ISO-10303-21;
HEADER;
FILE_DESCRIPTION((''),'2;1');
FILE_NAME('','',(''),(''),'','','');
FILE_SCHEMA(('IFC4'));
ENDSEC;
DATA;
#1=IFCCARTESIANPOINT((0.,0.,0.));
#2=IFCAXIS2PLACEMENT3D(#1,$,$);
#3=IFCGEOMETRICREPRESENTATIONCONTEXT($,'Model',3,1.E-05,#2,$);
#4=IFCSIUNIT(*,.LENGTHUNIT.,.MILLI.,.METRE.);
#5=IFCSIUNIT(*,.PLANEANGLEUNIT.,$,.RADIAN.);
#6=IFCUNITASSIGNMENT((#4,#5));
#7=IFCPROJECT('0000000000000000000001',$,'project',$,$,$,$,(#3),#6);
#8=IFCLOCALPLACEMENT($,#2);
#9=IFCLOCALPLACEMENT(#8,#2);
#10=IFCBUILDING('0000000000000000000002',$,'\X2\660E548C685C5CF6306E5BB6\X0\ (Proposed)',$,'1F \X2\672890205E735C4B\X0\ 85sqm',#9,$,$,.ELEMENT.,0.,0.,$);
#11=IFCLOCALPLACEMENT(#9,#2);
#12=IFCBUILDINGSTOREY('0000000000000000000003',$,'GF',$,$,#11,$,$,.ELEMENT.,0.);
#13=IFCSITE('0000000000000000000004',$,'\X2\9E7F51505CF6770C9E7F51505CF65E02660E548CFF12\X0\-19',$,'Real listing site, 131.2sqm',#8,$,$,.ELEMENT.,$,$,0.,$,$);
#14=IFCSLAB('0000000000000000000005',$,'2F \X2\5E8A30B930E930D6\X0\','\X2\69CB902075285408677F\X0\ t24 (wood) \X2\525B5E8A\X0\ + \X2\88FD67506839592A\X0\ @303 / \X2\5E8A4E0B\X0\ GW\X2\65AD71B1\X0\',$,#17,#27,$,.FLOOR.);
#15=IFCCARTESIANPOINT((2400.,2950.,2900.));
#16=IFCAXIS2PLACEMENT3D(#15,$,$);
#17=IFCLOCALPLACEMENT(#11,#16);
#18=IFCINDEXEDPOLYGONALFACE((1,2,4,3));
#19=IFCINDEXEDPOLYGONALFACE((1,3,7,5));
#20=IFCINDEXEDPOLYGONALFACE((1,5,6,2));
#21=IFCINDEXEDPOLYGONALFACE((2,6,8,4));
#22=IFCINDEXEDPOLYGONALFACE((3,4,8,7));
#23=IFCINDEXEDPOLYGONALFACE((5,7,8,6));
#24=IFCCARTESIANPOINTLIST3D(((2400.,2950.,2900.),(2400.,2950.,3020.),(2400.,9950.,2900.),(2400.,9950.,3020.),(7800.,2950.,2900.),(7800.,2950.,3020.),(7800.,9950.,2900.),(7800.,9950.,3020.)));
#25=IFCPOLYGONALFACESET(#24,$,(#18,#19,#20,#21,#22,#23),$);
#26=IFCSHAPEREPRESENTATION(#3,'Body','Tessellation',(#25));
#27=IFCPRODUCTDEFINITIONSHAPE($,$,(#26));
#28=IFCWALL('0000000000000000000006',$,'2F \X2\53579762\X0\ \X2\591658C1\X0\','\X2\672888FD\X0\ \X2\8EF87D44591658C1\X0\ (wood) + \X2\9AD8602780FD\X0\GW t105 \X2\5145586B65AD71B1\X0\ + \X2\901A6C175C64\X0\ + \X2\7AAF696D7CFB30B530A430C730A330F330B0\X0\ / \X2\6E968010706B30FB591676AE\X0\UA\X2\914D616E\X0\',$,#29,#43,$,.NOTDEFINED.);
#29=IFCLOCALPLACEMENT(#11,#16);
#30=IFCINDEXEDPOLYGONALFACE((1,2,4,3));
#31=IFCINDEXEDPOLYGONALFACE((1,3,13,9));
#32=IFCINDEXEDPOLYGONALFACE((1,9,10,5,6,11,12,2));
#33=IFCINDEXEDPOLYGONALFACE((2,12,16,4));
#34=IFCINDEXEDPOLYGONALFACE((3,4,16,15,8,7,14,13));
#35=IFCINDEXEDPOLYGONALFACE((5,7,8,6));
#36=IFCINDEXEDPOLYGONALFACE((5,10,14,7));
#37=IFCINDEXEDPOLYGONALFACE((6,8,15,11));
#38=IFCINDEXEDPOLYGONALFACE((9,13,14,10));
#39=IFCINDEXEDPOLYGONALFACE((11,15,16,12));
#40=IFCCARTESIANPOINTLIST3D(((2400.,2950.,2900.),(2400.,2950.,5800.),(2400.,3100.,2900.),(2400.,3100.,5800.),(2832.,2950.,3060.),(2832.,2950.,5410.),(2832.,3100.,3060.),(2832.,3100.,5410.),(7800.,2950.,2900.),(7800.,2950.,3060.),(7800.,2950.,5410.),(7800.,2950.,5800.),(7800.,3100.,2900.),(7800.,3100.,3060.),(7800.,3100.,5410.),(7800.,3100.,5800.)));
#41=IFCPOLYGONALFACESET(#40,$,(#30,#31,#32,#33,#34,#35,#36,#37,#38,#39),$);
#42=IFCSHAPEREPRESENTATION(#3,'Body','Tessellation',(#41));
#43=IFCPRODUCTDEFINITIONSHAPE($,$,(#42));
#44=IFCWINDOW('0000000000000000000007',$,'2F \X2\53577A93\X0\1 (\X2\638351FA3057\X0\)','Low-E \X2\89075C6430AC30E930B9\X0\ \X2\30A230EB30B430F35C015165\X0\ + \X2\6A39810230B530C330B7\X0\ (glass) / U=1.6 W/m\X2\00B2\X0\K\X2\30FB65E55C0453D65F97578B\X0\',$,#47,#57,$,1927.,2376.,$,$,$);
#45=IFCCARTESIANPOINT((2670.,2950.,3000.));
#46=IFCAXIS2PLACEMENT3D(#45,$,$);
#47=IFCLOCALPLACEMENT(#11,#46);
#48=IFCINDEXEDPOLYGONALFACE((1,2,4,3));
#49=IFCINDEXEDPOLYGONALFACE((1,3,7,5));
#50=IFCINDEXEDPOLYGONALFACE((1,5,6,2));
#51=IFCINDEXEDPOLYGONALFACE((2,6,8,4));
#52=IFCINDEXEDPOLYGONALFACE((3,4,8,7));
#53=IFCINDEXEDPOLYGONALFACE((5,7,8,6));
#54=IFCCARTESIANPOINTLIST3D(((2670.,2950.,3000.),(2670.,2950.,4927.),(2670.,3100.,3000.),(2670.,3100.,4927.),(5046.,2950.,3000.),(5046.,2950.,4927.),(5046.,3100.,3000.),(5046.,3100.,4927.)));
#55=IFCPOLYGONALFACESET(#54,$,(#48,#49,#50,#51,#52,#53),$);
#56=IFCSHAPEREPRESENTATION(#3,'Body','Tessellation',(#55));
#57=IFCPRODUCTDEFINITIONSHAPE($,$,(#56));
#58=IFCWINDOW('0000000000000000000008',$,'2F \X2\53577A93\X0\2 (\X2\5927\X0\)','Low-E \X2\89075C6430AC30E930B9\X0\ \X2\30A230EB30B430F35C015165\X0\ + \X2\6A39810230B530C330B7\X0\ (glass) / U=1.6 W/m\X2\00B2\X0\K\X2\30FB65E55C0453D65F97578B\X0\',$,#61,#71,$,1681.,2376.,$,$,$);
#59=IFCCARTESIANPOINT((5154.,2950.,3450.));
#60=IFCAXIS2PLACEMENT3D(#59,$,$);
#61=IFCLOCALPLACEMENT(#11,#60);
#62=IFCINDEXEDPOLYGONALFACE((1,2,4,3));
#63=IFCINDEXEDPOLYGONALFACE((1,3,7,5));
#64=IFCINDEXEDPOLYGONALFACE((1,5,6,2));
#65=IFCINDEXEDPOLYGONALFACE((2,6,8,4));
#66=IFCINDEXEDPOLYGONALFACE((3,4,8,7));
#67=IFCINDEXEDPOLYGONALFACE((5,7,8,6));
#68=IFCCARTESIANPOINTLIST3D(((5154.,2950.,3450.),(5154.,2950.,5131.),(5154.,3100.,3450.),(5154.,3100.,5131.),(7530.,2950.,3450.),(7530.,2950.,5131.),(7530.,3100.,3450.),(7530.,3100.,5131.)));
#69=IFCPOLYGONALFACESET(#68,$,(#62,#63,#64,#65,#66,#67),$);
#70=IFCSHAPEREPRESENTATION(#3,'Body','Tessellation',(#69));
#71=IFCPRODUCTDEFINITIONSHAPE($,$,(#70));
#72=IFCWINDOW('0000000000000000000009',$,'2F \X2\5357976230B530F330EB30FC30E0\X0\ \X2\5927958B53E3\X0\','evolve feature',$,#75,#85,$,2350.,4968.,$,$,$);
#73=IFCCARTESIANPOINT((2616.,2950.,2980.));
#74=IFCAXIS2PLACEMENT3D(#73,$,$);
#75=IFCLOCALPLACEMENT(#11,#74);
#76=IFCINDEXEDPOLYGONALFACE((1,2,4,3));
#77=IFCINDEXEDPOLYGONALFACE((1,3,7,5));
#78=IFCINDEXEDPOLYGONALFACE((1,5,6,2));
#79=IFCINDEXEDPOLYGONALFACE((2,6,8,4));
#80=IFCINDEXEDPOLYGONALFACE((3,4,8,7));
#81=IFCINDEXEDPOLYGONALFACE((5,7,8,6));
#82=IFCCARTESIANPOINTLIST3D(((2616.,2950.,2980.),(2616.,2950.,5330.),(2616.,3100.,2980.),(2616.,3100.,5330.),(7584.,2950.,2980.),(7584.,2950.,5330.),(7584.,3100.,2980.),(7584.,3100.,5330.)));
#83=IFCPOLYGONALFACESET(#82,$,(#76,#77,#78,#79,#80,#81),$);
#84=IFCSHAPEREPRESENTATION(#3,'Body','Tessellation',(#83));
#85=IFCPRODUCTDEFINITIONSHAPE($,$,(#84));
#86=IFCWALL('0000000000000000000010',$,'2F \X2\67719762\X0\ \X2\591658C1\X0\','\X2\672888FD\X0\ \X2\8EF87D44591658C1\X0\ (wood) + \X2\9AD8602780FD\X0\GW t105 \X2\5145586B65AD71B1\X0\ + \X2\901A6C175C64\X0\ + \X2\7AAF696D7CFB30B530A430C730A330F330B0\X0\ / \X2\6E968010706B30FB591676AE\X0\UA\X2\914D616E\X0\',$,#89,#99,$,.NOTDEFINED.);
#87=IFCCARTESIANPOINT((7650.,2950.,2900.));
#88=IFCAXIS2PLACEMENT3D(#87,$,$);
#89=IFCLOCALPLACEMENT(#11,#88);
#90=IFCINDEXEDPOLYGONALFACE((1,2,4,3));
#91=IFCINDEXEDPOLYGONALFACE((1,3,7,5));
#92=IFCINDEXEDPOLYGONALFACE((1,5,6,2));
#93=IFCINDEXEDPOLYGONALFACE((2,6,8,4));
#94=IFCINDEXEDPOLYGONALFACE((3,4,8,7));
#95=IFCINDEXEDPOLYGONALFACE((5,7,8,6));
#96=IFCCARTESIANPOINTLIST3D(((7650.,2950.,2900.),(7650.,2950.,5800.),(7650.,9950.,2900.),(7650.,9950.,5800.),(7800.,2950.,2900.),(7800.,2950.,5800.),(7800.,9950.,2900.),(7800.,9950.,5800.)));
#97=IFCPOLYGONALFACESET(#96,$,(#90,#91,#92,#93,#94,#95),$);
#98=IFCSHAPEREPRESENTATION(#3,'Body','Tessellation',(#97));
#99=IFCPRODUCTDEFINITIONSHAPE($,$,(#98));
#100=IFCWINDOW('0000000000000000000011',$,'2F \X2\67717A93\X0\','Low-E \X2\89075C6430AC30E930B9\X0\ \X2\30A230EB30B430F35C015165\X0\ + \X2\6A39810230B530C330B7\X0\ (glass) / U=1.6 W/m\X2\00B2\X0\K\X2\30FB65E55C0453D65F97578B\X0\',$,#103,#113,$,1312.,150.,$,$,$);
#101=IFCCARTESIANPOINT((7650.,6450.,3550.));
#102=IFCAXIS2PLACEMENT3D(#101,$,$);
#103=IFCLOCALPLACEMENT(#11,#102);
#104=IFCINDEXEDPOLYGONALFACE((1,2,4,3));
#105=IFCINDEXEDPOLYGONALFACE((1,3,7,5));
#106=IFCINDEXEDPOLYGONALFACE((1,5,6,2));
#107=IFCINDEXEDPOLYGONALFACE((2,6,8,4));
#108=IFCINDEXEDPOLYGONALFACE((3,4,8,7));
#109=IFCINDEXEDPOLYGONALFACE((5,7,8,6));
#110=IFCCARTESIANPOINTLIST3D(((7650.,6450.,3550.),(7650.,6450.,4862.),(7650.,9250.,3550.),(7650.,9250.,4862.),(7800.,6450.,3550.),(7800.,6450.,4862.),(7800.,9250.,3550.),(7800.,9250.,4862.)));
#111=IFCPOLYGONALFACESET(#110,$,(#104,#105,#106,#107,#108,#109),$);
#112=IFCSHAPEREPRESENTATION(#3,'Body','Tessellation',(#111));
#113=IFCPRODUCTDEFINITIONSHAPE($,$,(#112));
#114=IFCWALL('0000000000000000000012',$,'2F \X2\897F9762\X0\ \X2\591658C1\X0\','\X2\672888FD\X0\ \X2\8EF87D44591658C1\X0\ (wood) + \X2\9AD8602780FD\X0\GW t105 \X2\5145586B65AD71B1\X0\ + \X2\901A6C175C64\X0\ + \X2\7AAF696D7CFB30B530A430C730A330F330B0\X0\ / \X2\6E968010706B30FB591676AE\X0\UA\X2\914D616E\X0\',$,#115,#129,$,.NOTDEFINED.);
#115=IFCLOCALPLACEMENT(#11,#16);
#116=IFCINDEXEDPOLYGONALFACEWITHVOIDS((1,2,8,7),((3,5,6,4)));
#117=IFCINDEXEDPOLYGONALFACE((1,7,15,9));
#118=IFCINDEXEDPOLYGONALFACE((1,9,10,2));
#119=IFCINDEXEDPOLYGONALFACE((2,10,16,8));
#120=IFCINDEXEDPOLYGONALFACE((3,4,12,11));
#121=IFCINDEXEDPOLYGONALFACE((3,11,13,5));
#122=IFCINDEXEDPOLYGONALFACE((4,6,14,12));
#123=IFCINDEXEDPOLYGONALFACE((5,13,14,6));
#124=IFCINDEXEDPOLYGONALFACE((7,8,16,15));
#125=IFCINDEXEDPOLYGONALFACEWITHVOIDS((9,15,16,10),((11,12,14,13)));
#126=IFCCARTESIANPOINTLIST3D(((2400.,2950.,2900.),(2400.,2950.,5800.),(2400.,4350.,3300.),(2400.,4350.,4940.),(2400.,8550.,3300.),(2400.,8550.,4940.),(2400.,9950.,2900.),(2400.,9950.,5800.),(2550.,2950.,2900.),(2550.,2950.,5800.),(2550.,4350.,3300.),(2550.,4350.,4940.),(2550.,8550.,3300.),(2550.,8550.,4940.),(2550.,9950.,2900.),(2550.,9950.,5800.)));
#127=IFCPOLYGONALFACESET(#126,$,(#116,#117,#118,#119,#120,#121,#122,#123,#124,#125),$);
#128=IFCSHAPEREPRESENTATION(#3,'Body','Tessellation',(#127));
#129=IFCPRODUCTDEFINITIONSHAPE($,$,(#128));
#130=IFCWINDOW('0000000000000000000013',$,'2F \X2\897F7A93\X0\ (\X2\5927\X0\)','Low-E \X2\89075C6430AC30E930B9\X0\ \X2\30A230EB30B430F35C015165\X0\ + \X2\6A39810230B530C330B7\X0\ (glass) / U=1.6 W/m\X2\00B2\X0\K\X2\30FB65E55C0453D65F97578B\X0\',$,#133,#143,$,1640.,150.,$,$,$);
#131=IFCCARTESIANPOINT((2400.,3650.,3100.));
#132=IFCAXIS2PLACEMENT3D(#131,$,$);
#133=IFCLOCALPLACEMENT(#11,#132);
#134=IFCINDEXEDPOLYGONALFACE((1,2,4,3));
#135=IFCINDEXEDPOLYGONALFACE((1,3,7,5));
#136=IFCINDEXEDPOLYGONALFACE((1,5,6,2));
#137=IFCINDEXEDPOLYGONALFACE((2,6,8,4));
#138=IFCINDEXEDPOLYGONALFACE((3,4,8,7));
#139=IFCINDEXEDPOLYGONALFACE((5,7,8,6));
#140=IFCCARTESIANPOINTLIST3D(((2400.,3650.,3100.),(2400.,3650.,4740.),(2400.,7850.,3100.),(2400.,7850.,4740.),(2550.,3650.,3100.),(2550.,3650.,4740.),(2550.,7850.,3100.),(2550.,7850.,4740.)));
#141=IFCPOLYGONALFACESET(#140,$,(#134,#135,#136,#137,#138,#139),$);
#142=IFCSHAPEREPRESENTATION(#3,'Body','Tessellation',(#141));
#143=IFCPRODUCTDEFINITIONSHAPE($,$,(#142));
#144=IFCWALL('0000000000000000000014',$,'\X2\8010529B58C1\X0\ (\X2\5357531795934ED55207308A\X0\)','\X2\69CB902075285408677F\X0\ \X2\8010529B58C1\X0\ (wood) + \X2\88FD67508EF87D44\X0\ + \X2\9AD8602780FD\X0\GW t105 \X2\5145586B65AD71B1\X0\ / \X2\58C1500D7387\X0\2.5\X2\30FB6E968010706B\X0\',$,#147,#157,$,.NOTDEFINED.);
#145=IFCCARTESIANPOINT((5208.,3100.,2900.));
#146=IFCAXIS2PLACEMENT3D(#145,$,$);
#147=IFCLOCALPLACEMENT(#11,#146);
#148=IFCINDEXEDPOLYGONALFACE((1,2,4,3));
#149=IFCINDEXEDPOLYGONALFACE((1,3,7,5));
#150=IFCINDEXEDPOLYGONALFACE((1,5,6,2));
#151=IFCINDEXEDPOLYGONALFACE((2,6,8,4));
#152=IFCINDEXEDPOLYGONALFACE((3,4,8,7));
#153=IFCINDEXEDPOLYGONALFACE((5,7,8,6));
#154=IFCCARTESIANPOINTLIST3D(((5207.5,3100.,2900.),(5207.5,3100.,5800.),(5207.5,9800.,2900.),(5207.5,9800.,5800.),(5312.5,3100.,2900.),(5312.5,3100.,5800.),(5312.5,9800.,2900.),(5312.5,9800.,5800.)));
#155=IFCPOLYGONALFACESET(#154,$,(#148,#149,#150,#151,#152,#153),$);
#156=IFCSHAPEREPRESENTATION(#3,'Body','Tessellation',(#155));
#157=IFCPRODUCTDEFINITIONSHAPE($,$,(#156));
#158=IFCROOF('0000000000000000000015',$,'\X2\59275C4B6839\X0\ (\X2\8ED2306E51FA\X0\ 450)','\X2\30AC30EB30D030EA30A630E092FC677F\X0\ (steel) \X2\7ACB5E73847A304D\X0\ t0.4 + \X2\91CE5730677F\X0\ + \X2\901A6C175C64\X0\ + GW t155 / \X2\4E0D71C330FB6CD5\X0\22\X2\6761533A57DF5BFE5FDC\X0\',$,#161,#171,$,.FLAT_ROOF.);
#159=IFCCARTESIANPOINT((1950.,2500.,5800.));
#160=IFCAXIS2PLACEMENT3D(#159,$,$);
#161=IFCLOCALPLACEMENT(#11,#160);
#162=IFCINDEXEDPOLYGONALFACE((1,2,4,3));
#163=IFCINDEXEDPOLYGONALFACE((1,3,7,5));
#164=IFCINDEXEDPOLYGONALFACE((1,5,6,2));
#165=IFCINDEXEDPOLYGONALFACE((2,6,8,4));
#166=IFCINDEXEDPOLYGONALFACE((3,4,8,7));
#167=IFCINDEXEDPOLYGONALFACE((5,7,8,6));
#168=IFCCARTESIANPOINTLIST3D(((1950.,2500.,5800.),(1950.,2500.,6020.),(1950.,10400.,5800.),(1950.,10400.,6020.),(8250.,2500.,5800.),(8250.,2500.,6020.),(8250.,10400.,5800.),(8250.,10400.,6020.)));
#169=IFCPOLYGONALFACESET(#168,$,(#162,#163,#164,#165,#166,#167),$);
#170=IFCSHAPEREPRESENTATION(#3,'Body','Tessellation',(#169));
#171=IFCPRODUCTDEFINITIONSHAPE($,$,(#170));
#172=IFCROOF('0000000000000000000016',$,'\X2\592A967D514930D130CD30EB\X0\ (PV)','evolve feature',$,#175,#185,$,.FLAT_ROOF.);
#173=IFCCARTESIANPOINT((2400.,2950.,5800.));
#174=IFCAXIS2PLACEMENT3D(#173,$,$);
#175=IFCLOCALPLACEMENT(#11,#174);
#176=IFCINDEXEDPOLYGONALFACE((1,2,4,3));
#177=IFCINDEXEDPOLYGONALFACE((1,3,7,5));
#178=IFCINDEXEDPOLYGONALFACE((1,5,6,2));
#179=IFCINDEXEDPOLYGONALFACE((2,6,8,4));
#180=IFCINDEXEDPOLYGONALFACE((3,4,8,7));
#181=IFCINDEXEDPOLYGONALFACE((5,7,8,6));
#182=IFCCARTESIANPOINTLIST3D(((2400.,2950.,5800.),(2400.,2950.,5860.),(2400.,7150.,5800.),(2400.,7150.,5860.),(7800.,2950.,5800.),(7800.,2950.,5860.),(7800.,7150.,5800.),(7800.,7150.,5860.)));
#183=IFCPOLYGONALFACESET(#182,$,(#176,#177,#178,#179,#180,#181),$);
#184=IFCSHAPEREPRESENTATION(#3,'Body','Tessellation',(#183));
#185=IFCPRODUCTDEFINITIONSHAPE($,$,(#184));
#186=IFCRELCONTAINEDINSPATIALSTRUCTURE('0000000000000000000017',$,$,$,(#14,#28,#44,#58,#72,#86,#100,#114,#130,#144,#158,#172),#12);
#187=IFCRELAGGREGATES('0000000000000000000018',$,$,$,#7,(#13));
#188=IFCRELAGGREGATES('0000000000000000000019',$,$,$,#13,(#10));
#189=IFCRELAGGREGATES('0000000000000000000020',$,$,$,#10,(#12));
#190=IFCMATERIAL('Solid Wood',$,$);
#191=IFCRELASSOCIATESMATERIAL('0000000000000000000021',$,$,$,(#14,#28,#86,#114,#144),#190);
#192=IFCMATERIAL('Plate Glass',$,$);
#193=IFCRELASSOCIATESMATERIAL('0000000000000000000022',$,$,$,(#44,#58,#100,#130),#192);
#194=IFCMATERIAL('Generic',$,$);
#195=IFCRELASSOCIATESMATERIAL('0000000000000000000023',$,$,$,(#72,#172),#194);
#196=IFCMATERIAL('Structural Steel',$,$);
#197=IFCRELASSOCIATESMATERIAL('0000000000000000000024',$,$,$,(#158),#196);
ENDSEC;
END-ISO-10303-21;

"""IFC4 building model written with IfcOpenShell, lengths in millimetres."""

from ifc_helpers import new_model, si_unit, frame, frame_2d, origin, place, context, project, spatial, rectangle, extrude, material, element, fill, save


model = new_model("IFC4")

# Units and contexts
model_context = context("Model", 3, precision=1e-05, world=origin())
ifc_project = project(units=[si_unit("LENGTHUNIT", "METRE", prefix="MILLI"), si_unit("PLANEANGLEUNIT", "RADIAN")], contexts=[model_context])

# Site, building, storey
site_placement = place(None, origin())
site = spatial("IfcSite", under=ifc_project, at=site_placement, Name="鹿児島県鹿児島市明和２-19", ObjectType="Real listing site, 131.2sqm", CompositionType="ELEMENT", RefElevation=0.0)
building_placement = place(site_placement, origin())
building = spatial("IfcBuilding", under=site, at=building_placement, Name="明和桜島の家 (Proposed)", ObjectType="1F 木造平屋 85sqm", CompositionType="ELEMENT", ElevationOfRefHeight=0.0, ElevationOfTerrain=0.0)
storey_placement = place(building_placement, origin())
storey = spatial("IfcBuildingStorey", under=building, at=storey_placement, Name="GF", CompositionType="ELEMENT", Elevation=0.0)

# Slab
ifc_material_1 = material(Name="Solid Wood")
slab_placement = place(storey_placement, frame((2400.0, 2950.0, 2900.0)))
element("IfcSlab", 1, at=slab_placement, inside=storey, material=ifc_material_1, Name="2F 床スラブ", Description="構造用合板 t24 (wood) 剛床 + 製材根太 @303 / 床下 GW断熱", PredefinedType="FLOOR", context=model_context, shape_type="SweptSolid", body=[
    extrude(rectangle(XDim=5400.0, YDim=7000.0, at=frame_2d((2700.0, 3500.0))), frame((2400.0, 2950.0, 2900.0)), (0.0, 0.0, 1.0), 120.0),
])

# Wall, openings, windows
wall_1_placement = place(storey_placement, frame((2400.0, 2950.0, 2900.0)))
wall_1 = element("IfcWall", 2, at=wall_1_placement, inside=storey, material=ifc_material_1, Name="2F 南面 外壁", Description="木製 軸組外壁 (wood) + 高性能GW t105 充填断熱 + 通気層 + 窯業系サイディング / 準耐火・外皮UA配慮", PredefinedType="NOTDEFINED", context=model_context, shape_type="SweptSolid", body=[
    extrude(rectangle(XDim=5400.0, YDim=150.0, at=frame_2d((2700.0, 75.0))), frame((2400.0, 2950.0, 2900.0)), (0.0, 0.0, 1.0), 2900.0),
])
opening_1_placement = place(storey_placement, frame((2670.0, 2950.0, 3000.0)))
opening_1 = element("IfcOpeningElement", 3, at=opening_1_placement, cuts=wall_1, PredefinedType="NOTDEFINED", context=model_context, shape_type="SweptSolid", body=[
    extrude(rectangle(XDim=2376.0, YDim=150.0, at=frame_2d((1188.0, 75.0))), frame((2670.0, 2950.0, 3000.0)), (0.0, 0.0, 1.0), 1927.0),
])
opening_2_placement = place(storey_placement, frame((5154.0, 2950.0, 3450.0)))
opening_2 = element("IfcOpeningElement", 4, at=opening_2_placement, cuts=wall_1, PredefinedType="NOTDEFINED", context=model_context, shape_type="SweptSolid", body=[
    extrude(rectangle(XDim=2376.0, YDim=150.0, at=frame_2d((1188.0, 75.0))), frame((5154.0, 2950.0, 3450.0)), (0.0, 0.0, 1.0), 1681.0),
])
opening_3_placement = place(storey_placement, frame((2616.0, 2950.0, 2980.0)))
opening_3 = element("IfcOpeningElement", 5, at=opening_3_placement, cuts=wall_1, PredefinedType="NOTDEFINED", context=model_context, shape_type="SweptSolid", body=[
    extrude(rectangle(XDim=4968.0, YDim=150.0, at=frame_2d((2484.0, 75.0))), frame((2616.0, 2950.0, 2980.0)), (0.0, 0.0, 1.0), 2350.0),
])
ifc_material_2 = material(Name="Plate Glass")
window_1_placement = place(storey_placement, frame((2670.0, 2950.0, 3000.0)))
window_1 = element("IfcWindow", 6, at=window_1_placement, inside=storey, material=ifc_material_2, Name="2F 南窓1 (掃出し)", Description="Low-E 複層ガラス アルゴン封入 + 樹脂サッシ (glass) / U=1.6 W/m²K・日射取得型", OverallHeight=1927.0, OverallWidth=2376.0, context=model_context, shape_type="SweptSolid", body=[
    extrude(rectangle(XDim=2376.0, YDim=150.0, at=frame_2d((1188.0, 75.0))), frame((2670.0, 2950.0, 3000.0)), (0.0, 0.0, 1.0), 1927.0),
])
fill(opening_1, window_1)
window_2_placement = place(storey_placement, frame((5154.0, 2950.0, 3450.0)))
window_2 = element("IfcWindow", 7, at=window_2_placement, inside=storey, material=ifc_material_2, Name="2F 南窓2 (大)", Description="Low-E 複層ガラス アルゴン封入 + 樹脂サッシ (glass) / U=1.6 W/m²K・日射取得型", OverallHeight=1681.0, OverallWidth=2376.0, context=model_context, shape_type="SweptSolid", body=[
    extrude(rectangle(XDim=2376.0, YDim=150.0, at=frame_2d((1188.0, 75.0))), frame((5154.0, 2950.0, 3450.0)), (0.0, 0.0, 1.0), 1681.0),
])
fill(opening_2, window_2)
ifc_material_3 = material(Name="Generic")
window_3_placement = place(storey_placement, frame((2616.0, 2950.0, 2980.0)))
window_3 = element("IfcWindow", 8, at=window_3_placement, inside=storey, material=ifc_material_3, Name="2F 南面サンルーム 大開口", Description="evolve feature", OverallHeight=2350.0, OverallWidth=4968.0, context=model_context, shape_type="SweptSolid", body=[
    extrude(rectangle(XDim=4968.0, YDim=150.0, at=frame_2d((2484.0, 75.0))), frame((2616.0, 2950.0, 2980.0)), (0.0, 0.0, 1.0), 2350.0),
])
fill(opening_3, window_3)

# Walls, openings, windows
wall_2_placement = place(storey_placement, frame((7650.0, 2950.0, 2900.0)))
wall_2 = element("IfcWall", 9, at=wall_2_placement, inside=storey, material=ifc_material_1, Name="2F 東面 外壁", Description="木製 軸組外壁 (wood) + 高性能GW t105 充填断熱 + 通気層 + 窯業系サイディング / 準耐火・外皮UA配慮", PredefinedType="NOTDEFINED", context=model_context, shape_type="SweptSolid", body=[
    extrude(rectangle(XDim=150.0, YDim=7000.0, at=frame_2d((75.0, 3500.0))), frame((7650.0, 2950.0, 2900.0)), (0.0, 0.0, 1.0), 2900.0),
])
opening_4_placement = place(storey_placement, frame((7650.0, 6450.0, 3550.0)))
opening_4 = element("IfcOpeningElement", 10, at=opening_4_placement, cuts=wall_2, PredefinedType="NOTDEFINED", context=model_context, shape_type="SweptSolid", body=[
    extrude(rectangle(XDim=150.0, YDim=2800.0, at=frame_2d((75.0, 1400.0))), frame((7650.0, 6450.0, 3550.0)), (0.0, 0.0, 1.0), 1312.0),
])
window_4_placement = place(storey_placement, frame((7650.0, 6450.0, 3550.0)))
window_4 = element("IfcWindow", 11, at=window_4_placement, inside=storey, material=ifc_material_2, Name="2F 東窓", Description="Low-E 複層ガラス アルゴン封入 + 樹脂サッシ (glass) / U=1.6 W/m²K・日射取得型", OverallHeight=1312.0, OverallWidth=150.0, context=model_context, shape_type="SweptSolid", body=[
    extrude(rectangle(XDim=150.0, YDim=2800.0, at=frame_2d((75.0, 1400.0))), frame((7650.0, 6450.0, 3550.0)), (0.0, 0.0, 1.0), 1312.0),
])
fill(opening_4, window_4)
wall_3_placement = place(storey_placement, frame((2400.0, 2950.0, 2900.0)))
wall_3 = element("IfcWall", 12, at=wall_3_placement, inside=storey, material=ifc_material_1, Name="2F 西面 外壁", Description="木製 軸組外壁 (wood) + 高性能GW t105 充填断熱 + 通気層 + 窯業系サイディング / 準耐火・外皮UA配慮", PredefinedType="NOTDEFINED", context=model_context, shape_type="SweptSolid", body=[
    extrude(rectangle(XDim=150.0, YDim=7000.0, at=frame_2d((75.0, 3500.0))), frame((2400.0, 2950.0, 2900.0)), (0.0, 0.0, 1.0), 2900.0),
])
opening_5_placement = place(storey_placement, frame((2400.0, 3650.0, 3100.0)))
opening_5 = element("IfcOpeningElement", 13, at=opening_5_placement, cuts=wall_3, PredefinedType="NOTDEFINED", context=model_context, shape_type="SweptSolid", body=[
    extrude(rectangle(XDim=150.0, YDim=4200.0, at=frame_2d((75.0, 2100.0))), frame((2400.0, 3650.0, 3100.0)), (0.0, 0.0, 1.0), 1640.0),
])
window_5_placement = place(storey_placement, frame((2400.0, 3650.0, 3100.0)))
window_5 = element("IfcWindow", 14, at=window_5_placement, inside=storey, material=ifc_material_2, Name="2F 西窓 (大)", Description="Low-E 複層ガラス アルゴン封入 + 樹脂サッシ (glass) / U=1.6 W/m²K・日射取得型", OverallHeight=1640.0, OverallWidth=150.0, context=model_context, shape_type="SweptSolid", body=[
    extrude(rectangle(XDim=150.0, YDim=4200.0, at=frame_2d((75.0, 2100.0))), frame((2400.0, 3650.0, 3100.0)), (0.0, 0.0, 1.0), 1640.0),
])
fill(opening_5, window_5)

# Wall
wall_4_placement = place(storey_placement, frame((5208.0, 3100.0, 2900.0)))
element("IfcWall", 15, at=wall_4_placement, inside=storey, material=ifc_material_1, Name="耐力壁 (南北間仕切り)", Description="構造用合板 耐力壁 (wood) + 製材軸組 + 高性能GW t105 充填断熱 / 壁倍率2.5・準耐火", PredefinedType="NOTDEFINED", context=model_context, shape_type="SweptSolid", body=[
    extrude(rectangle(XDim=105.0, YDim=6700.0, at=frame_2d((52.0, 3350.0))), frame((5208.0, 3100.0, 2900.0)), (0.0, 0.0, 1.0), 2900.0),
])

# Roofs
ifc_material_4 = material(Name="Structural Steel")
roof_1_placement = place(storey_placement, frame((1950.0, 2500.0, 5800.0)))
element("IfcRoof", 16, at=roof_1_placement, inside=storey, material=ifc_material_4, Name="大屋根 (軒の出 450)", Description="ガルバリウム鋼板 (steel) 立平葺き t0.4 + 野地板 + 通気層 + GW t155 / 不燃・法22条区域対応", PredefinedType="FLAT_ROOF", context=model_context, shape_type="SweptSolid", body=[
    extrude(rectangle(XDim=6300.0, YDim=7900.0, at=frame_2d((3150.0, 3950.0))), frame((1950.0, 2500.0, 5800.0)), (0.0, 0.0, 1.0), 220.0),
])
roof_2_placement = place(storey_placement, frame((2400.0, 2950.0, 5800.0)))
element("IfcRoof", 17, at=roof_2_placement, inside=storey, material=ifc_material_3, Name="太陽光パネル (PV)", Description="evolve feature", PredefinedType="FLAT_ROOF", context=model_context, shape_type="SweptSolid", body=[
    extrude(rectangle(XDim=5400.0, YDim=4200.0, at=frame_2d((2700.0, 2100.0))), frame((2400.0, 2950.0, 5800.0)), (0.0, 0.0, 1.0), 60.0),
])

save(model, "model.ifc")
